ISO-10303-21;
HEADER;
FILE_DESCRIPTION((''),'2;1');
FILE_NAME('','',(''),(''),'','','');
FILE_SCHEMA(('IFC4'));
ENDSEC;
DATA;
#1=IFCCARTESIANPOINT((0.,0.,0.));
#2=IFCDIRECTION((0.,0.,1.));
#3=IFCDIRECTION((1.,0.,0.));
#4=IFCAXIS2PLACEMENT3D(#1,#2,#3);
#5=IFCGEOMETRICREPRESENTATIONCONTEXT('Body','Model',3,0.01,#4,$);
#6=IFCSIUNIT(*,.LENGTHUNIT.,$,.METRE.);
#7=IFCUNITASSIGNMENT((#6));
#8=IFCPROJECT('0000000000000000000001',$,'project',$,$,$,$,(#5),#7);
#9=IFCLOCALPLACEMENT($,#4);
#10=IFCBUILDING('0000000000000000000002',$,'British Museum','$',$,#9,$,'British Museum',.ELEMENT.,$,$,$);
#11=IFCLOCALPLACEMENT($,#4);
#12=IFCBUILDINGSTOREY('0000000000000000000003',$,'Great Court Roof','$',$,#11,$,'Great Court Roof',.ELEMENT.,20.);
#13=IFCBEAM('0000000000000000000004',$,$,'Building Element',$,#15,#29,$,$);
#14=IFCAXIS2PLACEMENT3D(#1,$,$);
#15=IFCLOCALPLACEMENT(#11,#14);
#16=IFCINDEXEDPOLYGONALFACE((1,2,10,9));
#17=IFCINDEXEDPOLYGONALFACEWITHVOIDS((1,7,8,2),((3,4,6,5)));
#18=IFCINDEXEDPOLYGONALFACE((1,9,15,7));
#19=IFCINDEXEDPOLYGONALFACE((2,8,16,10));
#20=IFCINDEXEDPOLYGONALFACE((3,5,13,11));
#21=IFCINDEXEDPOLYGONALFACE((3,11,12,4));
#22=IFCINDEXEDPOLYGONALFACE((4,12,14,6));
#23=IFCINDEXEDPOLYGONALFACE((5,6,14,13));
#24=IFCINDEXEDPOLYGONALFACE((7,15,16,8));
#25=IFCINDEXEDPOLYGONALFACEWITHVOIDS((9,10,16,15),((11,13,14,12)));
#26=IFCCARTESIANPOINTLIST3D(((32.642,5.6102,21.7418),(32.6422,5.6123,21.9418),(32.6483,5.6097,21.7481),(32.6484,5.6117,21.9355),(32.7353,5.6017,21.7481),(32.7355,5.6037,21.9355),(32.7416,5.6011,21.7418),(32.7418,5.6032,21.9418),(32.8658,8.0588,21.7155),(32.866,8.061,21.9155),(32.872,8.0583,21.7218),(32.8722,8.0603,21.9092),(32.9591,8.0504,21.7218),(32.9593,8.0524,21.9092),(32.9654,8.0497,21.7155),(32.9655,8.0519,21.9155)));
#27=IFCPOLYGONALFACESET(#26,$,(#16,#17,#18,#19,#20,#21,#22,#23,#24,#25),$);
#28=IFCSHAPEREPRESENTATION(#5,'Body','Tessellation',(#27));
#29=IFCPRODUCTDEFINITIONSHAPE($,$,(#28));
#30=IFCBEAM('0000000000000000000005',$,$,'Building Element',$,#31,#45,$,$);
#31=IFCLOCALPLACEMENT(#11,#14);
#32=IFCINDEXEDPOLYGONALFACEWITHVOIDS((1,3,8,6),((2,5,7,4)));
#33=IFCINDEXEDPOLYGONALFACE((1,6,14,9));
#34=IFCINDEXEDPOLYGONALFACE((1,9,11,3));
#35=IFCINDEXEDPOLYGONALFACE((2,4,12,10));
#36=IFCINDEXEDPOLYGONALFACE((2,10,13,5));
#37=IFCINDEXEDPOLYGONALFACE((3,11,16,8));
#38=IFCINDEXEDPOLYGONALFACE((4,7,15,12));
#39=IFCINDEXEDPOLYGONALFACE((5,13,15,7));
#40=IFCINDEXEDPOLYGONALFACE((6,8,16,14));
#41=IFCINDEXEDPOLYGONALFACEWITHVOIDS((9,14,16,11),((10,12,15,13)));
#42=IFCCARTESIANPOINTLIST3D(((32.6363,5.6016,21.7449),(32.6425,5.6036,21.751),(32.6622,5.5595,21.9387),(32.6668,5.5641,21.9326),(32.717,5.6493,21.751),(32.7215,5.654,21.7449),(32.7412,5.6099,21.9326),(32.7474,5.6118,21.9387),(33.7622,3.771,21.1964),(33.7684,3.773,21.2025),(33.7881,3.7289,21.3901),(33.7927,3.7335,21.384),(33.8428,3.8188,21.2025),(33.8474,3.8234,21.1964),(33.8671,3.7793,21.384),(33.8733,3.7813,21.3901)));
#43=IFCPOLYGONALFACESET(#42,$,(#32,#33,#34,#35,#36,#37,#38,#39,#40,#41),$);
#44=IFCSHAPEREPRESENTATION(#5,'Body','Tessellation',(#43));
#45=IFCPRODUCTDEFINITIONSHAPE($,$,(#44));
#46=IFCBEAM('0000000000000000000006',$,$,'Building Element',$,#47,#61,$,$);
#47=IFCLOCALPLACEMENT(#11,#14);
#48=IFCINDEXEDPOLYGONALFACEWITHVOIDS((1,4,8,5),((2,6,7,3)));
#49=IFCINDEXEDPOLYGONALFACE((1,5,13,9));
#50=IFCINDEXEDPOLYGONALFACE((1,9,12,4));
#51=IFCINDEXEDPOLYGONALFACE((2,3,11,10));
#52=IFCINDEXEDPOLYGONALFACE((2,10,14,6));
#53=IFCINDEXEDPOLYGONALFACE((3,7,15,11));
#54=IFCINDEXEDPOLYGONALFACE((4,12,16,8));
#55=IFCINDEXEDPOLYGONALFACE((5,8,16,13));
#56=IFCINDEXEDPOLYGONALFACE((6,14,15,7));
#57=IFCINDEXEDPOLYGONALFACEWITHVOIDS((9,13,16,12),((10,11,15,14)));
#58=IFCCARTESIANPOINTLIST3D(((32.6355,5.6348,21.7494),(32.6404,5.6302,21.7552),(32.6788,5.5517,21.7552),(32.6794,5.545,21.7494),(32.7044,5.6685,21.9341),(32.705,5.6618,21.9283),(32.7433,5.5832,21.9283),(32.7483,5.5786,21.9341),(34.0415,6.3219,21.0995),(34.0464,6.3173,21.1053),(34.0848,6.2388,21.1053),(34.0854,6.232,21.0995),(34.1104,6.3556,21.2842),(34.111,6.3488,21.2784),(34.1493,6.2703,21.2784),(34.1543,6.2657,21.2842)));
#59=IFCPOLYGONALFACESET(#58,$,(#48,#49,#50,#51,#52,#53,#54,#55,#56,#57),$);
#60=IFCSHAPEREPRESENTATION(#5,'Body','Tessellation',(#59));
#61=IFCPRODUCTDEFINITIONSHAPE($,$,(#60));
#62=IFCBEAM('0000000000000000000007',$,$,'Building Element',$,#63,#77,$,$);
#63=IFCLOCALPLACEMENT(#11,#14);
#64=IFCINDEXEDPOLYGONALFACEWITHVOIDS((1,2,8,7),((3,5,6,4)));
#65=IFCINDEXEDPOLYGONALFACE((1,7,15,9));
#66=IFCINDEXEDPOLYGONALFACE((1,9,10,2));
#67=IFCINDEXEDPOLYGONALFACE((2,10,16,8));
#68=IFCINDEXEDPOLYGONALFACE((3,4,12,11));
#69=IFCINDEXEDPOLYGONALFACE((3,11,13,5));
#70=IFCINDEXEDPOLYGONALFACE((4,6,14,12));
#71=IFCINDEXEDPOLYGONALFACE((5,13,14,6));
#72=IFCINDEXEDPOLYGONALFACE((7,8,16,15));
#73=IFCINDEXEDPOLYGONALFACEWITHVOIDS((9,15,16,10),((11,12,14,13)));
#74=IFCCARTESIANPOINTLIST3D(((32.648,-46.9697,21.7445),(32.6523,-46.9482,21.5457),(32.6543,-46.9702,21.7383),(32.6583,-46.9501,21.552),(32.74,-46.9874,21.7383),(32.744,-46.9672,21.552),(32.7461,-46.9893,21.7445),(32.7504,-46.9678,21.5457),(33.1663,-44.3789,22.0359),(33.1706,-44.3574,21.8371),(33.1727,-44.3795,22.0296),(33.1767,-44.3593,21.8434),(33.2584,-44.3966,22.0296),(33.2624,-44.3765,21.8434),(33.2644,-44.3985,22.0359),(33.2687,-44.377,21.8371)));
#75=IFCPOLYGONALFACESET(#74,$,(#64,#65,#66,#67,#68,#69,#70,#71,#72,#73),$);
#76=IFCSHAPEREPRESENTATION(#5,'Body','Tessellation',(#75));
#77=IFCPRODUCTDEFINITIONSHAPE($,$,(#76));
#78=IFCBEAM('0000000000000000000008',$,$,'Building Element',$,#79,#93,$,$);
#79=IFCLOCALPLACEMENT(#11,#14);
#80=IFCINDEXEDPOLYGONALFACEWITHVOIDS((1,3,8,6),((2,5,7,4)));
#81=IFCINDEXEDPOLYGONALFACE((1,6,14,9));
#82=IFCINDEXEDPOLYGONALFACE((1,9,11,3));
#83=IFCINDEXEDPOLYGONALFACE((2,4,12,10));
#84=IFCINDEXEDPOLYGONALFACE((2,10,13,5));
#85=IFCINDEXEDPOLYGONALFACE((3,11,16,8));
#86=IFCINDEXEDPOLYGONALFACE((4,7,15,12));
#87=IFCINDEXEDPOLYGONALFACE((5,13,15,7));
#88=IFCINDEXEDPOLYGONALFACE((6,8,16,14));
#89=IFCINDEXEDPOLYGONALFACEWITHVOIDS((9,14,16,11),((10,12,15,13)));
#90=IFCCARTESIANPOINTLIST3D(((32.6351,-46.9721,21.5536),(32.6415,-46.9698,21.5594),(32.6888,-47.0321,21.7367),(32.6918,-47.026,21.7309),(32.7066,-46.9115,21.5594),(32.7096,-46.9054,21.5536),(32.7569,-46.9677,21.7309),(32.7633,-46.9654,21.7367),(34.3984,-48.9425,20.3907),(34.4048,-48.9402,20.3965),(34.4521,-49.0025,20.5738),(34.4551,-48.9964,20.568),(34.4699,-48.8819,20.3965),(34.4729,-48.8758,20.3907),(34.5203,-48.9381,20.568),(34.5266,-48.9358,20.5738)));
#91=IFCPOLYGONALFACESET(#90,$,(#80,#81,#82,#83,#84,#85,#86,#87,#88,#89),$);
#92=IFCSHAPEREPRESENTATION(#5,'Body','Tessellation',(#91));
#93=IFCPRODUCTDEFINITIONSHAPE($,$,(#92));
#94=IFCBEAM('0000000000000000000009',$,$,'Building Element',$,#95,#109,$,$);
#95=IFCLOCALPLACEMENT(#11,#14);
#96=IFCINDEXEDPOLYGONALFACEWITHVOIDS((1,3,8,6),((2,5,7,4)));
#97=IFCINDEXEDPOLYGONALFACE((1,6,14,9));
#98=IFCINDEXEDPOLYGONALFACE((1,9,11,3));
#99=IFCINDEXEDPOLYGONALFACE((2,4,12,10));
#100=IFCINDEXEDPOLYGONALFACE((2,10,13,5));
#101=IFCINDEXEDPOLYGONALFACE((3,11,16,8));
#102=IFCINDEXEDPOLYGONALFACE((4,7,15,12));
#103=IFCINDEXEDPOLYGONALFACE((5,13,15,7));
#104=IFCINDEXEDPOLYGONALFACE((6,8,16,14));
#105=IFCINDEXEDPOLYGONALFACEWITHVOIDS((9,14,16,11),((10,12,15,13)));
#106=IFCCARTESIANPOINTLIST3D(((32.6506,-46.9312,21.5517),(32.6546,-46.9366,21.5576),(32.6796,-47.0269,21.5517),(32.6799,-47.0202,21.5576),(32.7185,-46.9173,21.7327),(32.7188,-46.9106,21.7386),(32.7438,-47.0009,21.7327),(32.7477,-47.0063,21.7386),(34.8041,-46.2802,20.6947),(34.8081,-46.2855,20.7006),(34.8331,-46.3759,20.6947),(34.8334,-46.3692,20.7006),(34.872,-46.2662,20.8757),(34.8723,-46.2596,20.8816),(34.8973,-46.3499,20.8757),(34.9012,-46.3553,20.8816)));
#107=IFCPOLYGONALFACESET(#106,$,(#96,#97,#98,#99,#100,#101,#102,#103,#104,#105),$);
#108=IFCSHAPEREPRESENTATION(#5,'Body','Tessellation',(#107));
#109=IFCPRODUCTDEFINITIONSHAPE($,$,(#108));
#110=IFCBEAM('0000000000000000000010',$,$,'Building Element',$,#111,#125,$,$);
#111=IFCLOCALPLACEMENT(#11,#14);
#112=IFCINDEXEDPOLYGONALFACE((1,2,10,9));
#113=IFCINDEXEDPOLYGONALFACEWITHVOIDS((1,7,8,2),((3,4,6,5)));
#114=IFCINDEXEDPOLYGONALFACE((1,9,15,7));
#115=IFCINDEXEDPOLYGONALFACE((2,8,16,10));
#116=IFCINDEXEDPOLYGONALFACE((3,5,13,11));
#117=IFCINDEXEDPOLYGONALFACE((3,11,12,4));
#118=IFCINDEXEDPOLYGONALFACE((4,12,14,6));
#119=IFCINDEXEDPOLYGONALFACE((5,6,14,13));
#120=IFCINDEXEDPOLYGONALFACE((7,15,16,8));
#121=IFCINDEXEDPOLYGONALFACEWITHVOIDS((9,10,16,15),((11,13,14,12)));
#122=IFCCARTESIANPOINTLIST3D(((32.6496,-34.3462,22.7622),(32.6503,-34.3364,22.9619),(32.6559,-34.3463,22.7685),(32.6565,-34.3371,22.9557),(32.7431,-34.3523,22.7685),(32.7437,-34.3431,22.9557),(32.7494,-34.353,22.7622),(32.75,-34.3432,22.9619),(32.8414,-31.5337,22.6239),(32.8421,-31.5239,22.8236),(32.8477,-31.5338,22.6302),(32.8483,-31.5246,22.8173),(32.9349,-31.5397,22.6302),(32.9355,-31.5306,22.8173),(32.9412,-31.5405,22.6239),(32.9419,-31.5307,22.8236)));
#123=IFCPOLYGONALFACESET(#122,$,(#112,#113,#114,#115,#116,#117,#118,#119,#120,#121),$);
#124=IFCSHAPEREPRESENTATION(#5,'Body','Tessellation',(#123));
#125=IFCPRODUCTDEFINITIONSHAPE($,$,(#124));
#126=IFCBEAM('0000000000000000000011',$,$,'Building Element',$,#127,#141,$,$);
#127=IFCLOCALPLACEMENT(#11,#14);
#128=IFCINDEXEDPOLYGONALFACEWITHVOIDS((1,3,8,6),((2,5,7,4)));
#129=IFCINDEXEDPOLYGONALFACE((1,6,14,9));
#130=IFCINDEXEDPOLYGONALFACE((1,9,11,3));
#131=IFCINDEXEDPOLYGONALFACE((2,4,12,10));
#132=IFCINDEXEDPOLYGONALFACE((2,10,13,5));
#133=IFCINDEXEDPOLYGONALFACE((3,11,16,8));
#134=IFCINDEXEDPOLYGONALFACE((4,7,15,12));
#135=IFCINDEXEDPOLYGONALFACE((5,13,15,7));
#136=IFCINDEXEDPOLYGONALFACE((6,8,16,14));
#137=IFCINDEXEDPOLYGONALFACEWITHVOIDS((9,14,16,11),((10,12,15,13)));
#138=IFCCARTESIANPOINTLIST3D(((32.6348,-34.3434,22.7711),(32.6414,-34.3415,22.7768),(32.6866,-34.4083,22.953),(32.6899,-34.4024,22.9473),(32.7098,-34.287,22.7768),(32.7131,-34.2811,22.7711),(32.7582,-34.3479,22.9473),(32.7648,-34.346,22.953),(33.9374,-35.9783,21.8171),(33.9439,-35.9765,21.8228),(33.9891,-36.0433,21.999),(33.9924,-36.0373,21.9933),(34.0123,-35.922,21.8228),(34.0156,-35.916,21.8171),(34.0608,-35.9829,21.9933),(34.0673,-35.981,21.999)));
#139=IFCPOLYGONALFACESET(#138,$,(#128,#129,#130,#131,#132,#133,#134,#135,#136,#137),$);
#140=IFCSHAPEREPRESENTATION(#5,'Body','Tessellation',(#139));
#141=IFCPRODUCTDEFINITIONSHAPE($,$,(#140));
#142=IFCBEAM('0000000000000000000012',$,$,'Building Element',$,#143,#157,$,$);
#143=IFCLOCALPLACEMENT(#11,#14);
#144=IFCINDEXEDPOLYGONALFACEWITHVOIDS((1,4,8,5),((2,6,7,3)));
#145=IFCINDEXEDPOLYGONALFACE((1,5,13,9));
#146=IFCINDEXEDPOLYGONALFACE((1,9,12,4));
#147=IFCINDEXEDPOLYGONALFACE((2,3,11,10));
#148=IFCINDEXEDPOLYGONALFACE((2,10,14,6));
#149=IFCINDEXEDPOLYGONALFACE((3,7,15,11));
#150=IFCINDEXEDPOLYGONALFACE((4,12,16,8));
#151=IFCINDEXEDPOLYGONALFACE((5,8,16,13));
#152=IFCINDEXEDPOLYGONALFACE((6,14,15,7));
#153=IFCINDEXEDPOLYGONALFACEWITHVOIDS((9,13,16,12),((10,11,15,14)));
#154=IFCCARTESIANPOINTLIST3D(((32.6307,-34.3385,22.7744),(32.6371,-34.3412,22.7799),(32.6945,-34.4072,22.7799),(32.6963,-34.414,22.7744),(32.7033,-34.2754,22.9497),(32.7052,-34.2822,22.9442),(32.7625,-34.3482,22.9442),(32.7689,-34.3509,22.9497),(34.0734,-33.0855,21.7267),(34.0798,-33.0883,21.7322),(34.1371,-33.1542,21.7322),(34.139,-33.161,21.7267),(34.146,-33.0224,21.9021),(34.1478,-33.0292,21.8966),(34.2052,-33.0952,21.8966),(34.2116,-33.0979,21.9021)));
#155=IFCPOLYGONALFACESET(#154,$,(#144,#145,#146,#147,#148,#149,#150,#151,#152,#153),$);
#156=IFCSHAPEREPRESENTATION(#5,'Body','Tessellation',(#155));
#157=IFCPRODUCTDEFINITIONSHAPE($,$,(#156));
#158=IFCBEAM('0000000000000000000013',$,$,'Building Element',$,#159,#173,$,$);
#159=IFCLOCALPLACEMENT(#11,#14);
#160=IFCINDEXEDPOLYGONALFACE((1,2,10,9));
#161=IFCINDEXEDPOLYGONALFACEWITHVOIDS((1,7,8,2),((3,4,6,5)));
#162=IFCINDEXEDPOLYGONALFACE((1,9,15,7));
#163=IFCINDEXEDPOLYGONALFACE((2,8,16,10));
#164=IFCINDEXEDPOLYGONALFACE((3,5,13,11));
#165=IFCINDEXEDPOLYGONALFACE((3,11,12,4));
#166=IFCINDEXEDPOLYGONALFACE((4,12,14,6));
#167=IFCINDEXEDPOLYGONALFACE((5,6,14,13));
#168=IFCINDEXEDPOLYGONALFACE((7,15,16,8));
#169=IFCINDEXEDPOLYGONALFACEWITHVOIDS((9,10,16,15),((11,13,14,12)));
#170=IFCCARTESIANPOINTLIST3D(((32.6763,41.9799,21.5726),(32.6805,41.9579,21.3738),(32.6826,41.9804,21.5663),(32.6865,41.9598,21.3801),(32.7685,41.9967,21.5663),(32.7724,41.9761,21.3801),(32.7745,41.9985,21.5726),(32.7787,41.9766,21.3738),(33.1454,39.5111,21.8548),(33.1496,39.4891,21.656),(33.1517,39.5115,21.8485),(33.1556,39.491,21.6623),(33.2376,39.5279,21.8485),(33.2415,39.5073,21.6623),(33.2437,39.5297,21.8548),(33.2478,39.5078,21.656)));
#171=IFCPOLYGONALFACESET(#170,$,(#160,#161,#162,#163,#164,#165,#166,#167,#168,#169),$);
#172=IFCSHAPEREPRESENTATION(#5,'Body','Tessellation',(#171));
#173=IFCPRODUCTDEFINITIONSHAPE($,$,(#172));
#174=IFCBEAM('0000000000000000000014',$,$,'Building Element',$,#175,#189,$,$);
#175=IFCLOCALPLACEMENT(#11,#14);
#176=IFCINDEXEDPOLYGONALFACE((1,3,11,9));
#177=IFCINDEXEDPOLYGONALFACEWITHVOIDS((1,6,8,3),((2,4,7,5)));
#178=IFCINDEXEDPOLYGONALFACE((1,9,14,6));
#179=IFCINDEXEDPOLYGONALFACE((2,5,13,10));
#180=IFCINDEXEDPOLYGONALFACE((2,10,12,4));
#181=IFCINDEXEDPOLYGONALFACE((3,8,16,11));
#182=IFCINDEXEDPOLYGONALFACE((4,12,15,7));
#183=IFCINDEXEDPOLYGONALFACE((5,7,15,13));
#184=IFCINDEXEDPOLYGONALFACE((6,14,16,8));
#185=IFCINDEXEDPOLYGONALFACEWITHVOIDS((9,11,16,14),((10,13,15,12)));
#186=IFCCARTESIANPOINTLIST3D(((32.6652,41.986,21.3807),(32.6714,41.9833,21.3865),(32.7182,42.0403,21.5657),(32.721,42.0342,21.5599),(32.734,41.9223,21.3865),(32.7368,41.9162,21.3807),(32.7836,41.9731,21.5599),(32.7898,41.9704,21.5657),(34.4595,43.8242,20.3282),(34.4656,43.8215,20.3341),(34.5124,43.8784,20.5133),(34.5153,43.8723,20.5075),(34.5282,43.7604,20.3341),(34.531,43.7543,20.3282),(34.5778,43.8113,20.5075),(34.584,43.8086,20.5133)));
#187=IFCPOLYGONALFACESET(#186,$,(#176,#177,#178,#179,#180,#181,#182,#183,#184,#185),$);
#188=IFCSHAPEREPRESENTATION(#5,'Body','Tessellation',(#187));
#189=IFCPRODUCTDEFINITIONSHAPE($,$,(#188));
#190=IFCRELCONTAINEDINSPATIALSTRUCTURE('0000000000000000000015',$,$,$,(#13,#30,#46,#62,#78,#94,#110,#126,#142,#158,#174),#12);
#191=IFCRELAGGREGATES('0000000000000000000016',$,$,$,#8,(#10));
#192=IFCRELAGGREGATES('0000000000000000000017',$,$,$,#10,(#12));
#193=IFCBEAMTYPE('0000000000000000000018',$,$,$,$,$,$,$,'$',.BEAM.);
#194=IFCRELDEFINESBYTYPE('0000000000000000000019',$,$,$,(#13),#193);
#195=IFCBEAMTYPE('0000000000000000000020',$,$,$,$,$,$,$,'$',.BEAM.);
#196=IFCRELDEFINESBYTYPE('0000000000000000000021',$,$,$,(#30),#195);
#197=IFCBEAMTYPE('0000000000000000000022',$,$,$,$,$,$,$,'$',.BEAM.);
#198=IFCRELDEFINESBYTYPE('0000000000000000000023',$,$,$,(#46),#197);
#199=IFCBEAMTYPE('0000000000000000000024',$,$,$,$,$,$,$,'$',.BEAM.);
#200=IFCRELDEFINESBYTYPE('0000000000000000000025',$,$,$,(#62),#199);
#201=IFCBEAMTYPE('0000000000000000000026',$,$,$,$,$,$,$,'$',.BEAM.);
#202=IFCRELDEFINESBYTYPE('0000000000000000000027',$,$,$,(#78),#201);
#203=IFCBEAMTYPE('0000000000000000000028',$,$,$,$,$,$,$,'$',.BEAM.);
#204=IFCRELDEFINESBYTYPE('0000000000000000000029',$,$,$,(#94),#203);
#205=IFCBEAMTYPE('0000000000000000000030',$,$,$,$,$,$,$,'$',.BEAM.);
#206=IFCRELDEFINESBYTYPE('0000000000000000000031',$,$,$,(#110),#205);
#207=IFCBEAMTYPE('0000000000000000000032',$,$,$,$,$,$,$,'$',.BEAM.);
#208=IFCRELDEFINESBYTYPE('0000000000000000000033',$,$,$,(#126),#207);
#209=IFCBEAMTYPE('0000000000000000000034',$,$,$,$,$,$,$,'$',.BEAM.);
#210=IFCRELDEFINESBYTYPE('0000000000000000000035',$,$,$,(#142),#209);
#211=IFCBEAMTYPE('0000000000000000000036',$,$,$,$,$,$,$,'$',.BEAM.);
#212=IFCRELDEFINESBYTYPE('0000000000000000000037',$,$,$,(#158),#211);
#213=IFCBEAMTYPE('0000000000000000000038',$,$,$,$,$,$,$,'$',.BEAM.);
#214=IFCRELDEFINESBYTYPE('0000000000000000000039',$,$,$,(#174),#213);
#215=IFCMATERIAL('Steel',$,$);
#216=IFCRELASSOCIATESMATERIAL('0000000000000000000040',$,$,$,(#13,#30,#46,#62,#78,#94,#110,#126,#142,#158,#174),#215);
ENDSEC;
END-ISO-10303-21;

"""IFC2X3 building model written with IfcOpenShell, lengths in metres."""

from ifc_helpers import new_model, si_unit, frame, origin_with_axes, origin_2d, place, context, project, spatial, hollow_rectangle, extrude, material, type_object, element, save


model = new_model("IFC2X3")

# Units and contexts
model_context = context("Model", 3, precision=0.01, world=origin_with_axes(), identifier="Body")
ifc_project = project(units=[si_unit("LENGTHUNIT", "METRE")], contexts=[model_context])

# Building, storey
building_placement = place(None, origin_with_axes())
building = spatial("IfcBuilding", under=ifc_project, at=building_placement, Name="British Museum", Description="$", LongName="British Museum", CompositionType="ELEMENT")
storey_placement = place(None, origin_with_axes())
storey = spatial("IfcBuildingStorey", under=building, at=storey_placement, Name="Great Court Roof", Description="$", LongName="Great Court Roof", CompositionType="ELEMENT", Elevation=20.0)

# Beams
ifc_material = material(Name="Steel")
beam_type_1 = type_object("IfcBeamType", ElementType="$", PredefinedType="BEAM")
beam_1_placement = place(None, origin_with_axes())
element("IfcBeam", 1, at=beam_1_placement, inside=storey, type_object=beam_type_1, material=ifc_material, Description="Building Element", context=model_context, shape_type="SweptSolid", body=[
    extrude(hollow_rectangle(XDim=0.1, YDim=0.2, WallThickness=0.0063, InnerFilletRadius=0.0, OuterFilletRadius=0.0, at=origin_2d()), frame((32.6919, 5.6067, 21.8418), z_axis=(0.091009, 0.995793, -0.010686), x_axis=(-0.99585, 0.091014, 0.0)), (0.0, 0.0, 1.0), 2.459),
])
beam_type_2 = type_object("IfcBeamType", ElementType="$", PredefinedType="BEAM")
beam_2_placement = place(None, origin_with_axes())
element("IfcBeam", 2, at=beam_2_placement, inside=storey, type_object=beam_type_2, material=ifc_material, Description="Building Element", context=model_context, shape_type="SweptSolid", body=[
    extrude(hollow_rectangle(XDim=0.1, YDim=0.2, WallThickness=0.0063, InnerFilletRadius=0.0, OuterFilletRadius=0.0, at=origin_2d()), frame((32.6919, 5.6067, 21.8418), z_axis=(0.507612, -0.825331, -0.247302), x_axis=(0.851789, 0.523885, 0.0)), (0.0, 0.0, 1.0), 2.218),
])
beam_type_3 = type_object("IfcBeamType", ElementType="$", PredefinedType="BEAM")
beam_3_placement = place(None, origin_with_axes())
element("IfcBeam", 3, at=beam_3_placement, inside=storey, type_object=beam_type_3, material=ifc_material, Description="Building Element", context=model_context, shape_type="SweptSolid", body=[
    extrude(hollow_rectangle(XDim=0.1, YDim=0.2, WallThickness=0.0063, InnerFilletRadius=0.0, OuterFilletRadius=0.0, at=origin_2d()), frame((32.6919, 5.6067, 21.8418), z_axis=(0.829751, 0.405483, -0.383531), x_axis=(-0.439059, 0.898458, 0.0)), (0.0, 0.0, 1.0), 1.6945),
])
beam_type_4 = type_object("IfcBeamType", ElementType="$", PredefinedType="BEAM")
beam_4_placement = place(None, origin_with_axes())
element("IfcBeam", 4, at=beam_4_placement, inside=storey, type_object=beam_type_4, material=ifc_material, Description="Building Element", context=model_context, shape_type="SweptSolid", body=[
    extrude(hollow_rectangle(XDim=0.1, YDim=0.2, WallThickness=0.0063, InnerFilletRadius=0.0, OuterFilletRadius=0.0, at=origin_2d()), frame((32.6992, -46.9687, 21.6451), z_axis=(0.195003, 0.974658, 0.109613), x_axis=(-0.980567, 0.196185, 0.0)), (0.0, 0.0, 1.0), 2.6581),
])
beam_type_5 = type_object("IfcBeamType", ElementType="$", PredefinedType="BEAM")
beam_5_placement = place(None, origin_with_axes())
element("IfcBeam", 5, at=beam_5_placement, inside=storey, type_object=beam_type_5, material=ifc_material, Description="Building Element", context=model_context, shape_type="SweptSolid", body=[
    extrude(hollow_rectangle(XDim=0.1, YDim=0.2, WallThickness=0.0063, InnerFilletRadius=0.0, OuterFilletRadius=0.0, at=origin_2d()), frame((32.6992, -46.9687, 21.6451), z_axis=(0.610446, -0.682121, -0.402575), x_axis=(0.745172, 0.666872, 0.0)), (0.0, 0.0, 1.0), 2.8886),
])
beam_type_6 = type_object("IfcBeamType", ElementType="$", PredefinedType="BEAM")
beam_6_placement = place(None, origin_with_axes())
element("IfcBeam", 6, at=beam_6_placement, inside=storey, type_object=beam_type_6, material=ifc_material, Description="Building Element", context=model_context, shape_type="SweptSolid", body=[
    extrude(hollow_rectangle(XDim=0.1, YDim=0.2, WallThickness=0.0063, InnerFilletRadius=0.0, OuterFilletRadius=0.0, at=origin_2d()), frame((32.6992, -46.9687, 21.6451), z_axis=(0.894513, 0.270419, -0.355977), x_axis=(-0.289374, 0.957216, 0.0)), (0.0, 0.0, 1.0), 2.4075),
])
beam_type_7 = type_object("IfcBeamType", ElementType="$", PredefinedType="BEAM")
beam_7_placement = place(None, origin_with_axes())
element("IfcBeam", 7, at=beam_7_placement, inside=storey, type_object=beam_type_7, material=ifc_material, Description="Building Element", context=model_context, shape_type="SweptSolid", body=[
    extrude(hollow_rectangle(XDim=0.1, YDim=0.2, WallThickness=0.0063, InnerFilletRadius=0.0, OuterFilletRadius=0.0, at=origin_2d()), frame((32.6998, -34.3447, 22.8621), z_axis=(0.067963, 0.996484, -0.049006), x_axis=(-0.997682, 0.068045, 0.0)), (0.0, 0.0, 1.0), 2.8224),
])
beam_type_8 = type_object("IfcBeamType", ElementType="$", PredefinedType="BEAM")
beam_8_placement = place(None, origin_with_axes())
element("IfcBeam", 8, at=beam_8_placement, inside=storey, type_object=beam_type_8, material=ifc_material, Description="Building Element", context=model_context, shape_type="SweptSolid", body=[
    extrude(hollow_rectangle(XDim=0.1, YDim=0.2, WallThickness=0.0063, InnerFilletRadius=0.0, OuterFilletRadius=0.0, at=origin_2d()), frame((32.6998, -34.3447, 22.8621), z_axis=(0.566869, -0.711537, -0.415181), x_axis=(0.782133, 0.623111, 0.0)), (0.0, 0.0, 1.0), 2.2978),
])
beam_type_9 = type_object("IfcBeamType", ElementType="$", PredefinedType="BEAM")
beam_9_placement = place(None, origin_with_axes())
element("IfcBeam", 9, at=beam_9_placement, inside=storey, type_object=beam_type_9, material=ifc_material, Description="Building Element", context=model_context, shape_type="SweptSolid", body=[
    extrude(hollow_rectangle(XDim=0.1, YDim=0.2, WallThickness=0.0063, InnerFilletRadius=0.0, OuterFilletRadius=0.0, at=origin_2d()), frame((32.6998, -34.3447, 22.8621), z_axis=(0.662023, 0.574975, -0.48076), x_axis=(-0.655726, 0.754999, 0.0)), (0.0, 0.0, 1.0), 2.1792),
])
beam_type_10 = type_object("IfcBeamType", ElementType="$", PredefinedType="BEAM")
beam_10_placement = place(None, origin_with_axes())
element("IfcBeam", 10, at=beam_10_placement, inside=storey, type_object=beam_type_10, material=ifc_material, Description="Building Element", context=model_context, shape_type="SweptSolid", body=[
    extrude(hollow_rectangle(XDim=0.1, YDim=0.2, WallThickness=0.0063, InnerFilletRadius=0.0, OuterFilletRadius=0.0, at=origin_2d()), frame((32.7275, 41.9782, 21.4732), z_axis=(0.185516, -0.976283, 0.111599), x_axis=(0.98242, 0.186683, 0.0)), (0.0, 0.0, 1.0), 2.5288),
])
beam_type_11 = type_object("IfcBeamType", ElementType="$", PredefinedType="BEAM")
beam_11_placement = place(None, origin_with_axes())
element("IfcBeam", 11, at=beam_11_placement, inside=storey, type_object=beam_type_11, material=ifc_material, Description="Building Element", context=model_context, shape_type="SweptSolid", body=[
    extrude(hollow_rectangle(XDim=0.1, YDim=0.2, WallThickness=0.0063, InnerFilletRadius=0.0, OuterFilletRadius=0.0, at=origin_2d()), frame((32.7275, 41.9782, 21.4732), z_axis=(0.646366, 0.662172, -0.379129), x_axis=(-0.715596, 0.698515, 0.0)), (0.0, 0.0, 1.0), 2.7759),
])

save(model, "model.ifc")
